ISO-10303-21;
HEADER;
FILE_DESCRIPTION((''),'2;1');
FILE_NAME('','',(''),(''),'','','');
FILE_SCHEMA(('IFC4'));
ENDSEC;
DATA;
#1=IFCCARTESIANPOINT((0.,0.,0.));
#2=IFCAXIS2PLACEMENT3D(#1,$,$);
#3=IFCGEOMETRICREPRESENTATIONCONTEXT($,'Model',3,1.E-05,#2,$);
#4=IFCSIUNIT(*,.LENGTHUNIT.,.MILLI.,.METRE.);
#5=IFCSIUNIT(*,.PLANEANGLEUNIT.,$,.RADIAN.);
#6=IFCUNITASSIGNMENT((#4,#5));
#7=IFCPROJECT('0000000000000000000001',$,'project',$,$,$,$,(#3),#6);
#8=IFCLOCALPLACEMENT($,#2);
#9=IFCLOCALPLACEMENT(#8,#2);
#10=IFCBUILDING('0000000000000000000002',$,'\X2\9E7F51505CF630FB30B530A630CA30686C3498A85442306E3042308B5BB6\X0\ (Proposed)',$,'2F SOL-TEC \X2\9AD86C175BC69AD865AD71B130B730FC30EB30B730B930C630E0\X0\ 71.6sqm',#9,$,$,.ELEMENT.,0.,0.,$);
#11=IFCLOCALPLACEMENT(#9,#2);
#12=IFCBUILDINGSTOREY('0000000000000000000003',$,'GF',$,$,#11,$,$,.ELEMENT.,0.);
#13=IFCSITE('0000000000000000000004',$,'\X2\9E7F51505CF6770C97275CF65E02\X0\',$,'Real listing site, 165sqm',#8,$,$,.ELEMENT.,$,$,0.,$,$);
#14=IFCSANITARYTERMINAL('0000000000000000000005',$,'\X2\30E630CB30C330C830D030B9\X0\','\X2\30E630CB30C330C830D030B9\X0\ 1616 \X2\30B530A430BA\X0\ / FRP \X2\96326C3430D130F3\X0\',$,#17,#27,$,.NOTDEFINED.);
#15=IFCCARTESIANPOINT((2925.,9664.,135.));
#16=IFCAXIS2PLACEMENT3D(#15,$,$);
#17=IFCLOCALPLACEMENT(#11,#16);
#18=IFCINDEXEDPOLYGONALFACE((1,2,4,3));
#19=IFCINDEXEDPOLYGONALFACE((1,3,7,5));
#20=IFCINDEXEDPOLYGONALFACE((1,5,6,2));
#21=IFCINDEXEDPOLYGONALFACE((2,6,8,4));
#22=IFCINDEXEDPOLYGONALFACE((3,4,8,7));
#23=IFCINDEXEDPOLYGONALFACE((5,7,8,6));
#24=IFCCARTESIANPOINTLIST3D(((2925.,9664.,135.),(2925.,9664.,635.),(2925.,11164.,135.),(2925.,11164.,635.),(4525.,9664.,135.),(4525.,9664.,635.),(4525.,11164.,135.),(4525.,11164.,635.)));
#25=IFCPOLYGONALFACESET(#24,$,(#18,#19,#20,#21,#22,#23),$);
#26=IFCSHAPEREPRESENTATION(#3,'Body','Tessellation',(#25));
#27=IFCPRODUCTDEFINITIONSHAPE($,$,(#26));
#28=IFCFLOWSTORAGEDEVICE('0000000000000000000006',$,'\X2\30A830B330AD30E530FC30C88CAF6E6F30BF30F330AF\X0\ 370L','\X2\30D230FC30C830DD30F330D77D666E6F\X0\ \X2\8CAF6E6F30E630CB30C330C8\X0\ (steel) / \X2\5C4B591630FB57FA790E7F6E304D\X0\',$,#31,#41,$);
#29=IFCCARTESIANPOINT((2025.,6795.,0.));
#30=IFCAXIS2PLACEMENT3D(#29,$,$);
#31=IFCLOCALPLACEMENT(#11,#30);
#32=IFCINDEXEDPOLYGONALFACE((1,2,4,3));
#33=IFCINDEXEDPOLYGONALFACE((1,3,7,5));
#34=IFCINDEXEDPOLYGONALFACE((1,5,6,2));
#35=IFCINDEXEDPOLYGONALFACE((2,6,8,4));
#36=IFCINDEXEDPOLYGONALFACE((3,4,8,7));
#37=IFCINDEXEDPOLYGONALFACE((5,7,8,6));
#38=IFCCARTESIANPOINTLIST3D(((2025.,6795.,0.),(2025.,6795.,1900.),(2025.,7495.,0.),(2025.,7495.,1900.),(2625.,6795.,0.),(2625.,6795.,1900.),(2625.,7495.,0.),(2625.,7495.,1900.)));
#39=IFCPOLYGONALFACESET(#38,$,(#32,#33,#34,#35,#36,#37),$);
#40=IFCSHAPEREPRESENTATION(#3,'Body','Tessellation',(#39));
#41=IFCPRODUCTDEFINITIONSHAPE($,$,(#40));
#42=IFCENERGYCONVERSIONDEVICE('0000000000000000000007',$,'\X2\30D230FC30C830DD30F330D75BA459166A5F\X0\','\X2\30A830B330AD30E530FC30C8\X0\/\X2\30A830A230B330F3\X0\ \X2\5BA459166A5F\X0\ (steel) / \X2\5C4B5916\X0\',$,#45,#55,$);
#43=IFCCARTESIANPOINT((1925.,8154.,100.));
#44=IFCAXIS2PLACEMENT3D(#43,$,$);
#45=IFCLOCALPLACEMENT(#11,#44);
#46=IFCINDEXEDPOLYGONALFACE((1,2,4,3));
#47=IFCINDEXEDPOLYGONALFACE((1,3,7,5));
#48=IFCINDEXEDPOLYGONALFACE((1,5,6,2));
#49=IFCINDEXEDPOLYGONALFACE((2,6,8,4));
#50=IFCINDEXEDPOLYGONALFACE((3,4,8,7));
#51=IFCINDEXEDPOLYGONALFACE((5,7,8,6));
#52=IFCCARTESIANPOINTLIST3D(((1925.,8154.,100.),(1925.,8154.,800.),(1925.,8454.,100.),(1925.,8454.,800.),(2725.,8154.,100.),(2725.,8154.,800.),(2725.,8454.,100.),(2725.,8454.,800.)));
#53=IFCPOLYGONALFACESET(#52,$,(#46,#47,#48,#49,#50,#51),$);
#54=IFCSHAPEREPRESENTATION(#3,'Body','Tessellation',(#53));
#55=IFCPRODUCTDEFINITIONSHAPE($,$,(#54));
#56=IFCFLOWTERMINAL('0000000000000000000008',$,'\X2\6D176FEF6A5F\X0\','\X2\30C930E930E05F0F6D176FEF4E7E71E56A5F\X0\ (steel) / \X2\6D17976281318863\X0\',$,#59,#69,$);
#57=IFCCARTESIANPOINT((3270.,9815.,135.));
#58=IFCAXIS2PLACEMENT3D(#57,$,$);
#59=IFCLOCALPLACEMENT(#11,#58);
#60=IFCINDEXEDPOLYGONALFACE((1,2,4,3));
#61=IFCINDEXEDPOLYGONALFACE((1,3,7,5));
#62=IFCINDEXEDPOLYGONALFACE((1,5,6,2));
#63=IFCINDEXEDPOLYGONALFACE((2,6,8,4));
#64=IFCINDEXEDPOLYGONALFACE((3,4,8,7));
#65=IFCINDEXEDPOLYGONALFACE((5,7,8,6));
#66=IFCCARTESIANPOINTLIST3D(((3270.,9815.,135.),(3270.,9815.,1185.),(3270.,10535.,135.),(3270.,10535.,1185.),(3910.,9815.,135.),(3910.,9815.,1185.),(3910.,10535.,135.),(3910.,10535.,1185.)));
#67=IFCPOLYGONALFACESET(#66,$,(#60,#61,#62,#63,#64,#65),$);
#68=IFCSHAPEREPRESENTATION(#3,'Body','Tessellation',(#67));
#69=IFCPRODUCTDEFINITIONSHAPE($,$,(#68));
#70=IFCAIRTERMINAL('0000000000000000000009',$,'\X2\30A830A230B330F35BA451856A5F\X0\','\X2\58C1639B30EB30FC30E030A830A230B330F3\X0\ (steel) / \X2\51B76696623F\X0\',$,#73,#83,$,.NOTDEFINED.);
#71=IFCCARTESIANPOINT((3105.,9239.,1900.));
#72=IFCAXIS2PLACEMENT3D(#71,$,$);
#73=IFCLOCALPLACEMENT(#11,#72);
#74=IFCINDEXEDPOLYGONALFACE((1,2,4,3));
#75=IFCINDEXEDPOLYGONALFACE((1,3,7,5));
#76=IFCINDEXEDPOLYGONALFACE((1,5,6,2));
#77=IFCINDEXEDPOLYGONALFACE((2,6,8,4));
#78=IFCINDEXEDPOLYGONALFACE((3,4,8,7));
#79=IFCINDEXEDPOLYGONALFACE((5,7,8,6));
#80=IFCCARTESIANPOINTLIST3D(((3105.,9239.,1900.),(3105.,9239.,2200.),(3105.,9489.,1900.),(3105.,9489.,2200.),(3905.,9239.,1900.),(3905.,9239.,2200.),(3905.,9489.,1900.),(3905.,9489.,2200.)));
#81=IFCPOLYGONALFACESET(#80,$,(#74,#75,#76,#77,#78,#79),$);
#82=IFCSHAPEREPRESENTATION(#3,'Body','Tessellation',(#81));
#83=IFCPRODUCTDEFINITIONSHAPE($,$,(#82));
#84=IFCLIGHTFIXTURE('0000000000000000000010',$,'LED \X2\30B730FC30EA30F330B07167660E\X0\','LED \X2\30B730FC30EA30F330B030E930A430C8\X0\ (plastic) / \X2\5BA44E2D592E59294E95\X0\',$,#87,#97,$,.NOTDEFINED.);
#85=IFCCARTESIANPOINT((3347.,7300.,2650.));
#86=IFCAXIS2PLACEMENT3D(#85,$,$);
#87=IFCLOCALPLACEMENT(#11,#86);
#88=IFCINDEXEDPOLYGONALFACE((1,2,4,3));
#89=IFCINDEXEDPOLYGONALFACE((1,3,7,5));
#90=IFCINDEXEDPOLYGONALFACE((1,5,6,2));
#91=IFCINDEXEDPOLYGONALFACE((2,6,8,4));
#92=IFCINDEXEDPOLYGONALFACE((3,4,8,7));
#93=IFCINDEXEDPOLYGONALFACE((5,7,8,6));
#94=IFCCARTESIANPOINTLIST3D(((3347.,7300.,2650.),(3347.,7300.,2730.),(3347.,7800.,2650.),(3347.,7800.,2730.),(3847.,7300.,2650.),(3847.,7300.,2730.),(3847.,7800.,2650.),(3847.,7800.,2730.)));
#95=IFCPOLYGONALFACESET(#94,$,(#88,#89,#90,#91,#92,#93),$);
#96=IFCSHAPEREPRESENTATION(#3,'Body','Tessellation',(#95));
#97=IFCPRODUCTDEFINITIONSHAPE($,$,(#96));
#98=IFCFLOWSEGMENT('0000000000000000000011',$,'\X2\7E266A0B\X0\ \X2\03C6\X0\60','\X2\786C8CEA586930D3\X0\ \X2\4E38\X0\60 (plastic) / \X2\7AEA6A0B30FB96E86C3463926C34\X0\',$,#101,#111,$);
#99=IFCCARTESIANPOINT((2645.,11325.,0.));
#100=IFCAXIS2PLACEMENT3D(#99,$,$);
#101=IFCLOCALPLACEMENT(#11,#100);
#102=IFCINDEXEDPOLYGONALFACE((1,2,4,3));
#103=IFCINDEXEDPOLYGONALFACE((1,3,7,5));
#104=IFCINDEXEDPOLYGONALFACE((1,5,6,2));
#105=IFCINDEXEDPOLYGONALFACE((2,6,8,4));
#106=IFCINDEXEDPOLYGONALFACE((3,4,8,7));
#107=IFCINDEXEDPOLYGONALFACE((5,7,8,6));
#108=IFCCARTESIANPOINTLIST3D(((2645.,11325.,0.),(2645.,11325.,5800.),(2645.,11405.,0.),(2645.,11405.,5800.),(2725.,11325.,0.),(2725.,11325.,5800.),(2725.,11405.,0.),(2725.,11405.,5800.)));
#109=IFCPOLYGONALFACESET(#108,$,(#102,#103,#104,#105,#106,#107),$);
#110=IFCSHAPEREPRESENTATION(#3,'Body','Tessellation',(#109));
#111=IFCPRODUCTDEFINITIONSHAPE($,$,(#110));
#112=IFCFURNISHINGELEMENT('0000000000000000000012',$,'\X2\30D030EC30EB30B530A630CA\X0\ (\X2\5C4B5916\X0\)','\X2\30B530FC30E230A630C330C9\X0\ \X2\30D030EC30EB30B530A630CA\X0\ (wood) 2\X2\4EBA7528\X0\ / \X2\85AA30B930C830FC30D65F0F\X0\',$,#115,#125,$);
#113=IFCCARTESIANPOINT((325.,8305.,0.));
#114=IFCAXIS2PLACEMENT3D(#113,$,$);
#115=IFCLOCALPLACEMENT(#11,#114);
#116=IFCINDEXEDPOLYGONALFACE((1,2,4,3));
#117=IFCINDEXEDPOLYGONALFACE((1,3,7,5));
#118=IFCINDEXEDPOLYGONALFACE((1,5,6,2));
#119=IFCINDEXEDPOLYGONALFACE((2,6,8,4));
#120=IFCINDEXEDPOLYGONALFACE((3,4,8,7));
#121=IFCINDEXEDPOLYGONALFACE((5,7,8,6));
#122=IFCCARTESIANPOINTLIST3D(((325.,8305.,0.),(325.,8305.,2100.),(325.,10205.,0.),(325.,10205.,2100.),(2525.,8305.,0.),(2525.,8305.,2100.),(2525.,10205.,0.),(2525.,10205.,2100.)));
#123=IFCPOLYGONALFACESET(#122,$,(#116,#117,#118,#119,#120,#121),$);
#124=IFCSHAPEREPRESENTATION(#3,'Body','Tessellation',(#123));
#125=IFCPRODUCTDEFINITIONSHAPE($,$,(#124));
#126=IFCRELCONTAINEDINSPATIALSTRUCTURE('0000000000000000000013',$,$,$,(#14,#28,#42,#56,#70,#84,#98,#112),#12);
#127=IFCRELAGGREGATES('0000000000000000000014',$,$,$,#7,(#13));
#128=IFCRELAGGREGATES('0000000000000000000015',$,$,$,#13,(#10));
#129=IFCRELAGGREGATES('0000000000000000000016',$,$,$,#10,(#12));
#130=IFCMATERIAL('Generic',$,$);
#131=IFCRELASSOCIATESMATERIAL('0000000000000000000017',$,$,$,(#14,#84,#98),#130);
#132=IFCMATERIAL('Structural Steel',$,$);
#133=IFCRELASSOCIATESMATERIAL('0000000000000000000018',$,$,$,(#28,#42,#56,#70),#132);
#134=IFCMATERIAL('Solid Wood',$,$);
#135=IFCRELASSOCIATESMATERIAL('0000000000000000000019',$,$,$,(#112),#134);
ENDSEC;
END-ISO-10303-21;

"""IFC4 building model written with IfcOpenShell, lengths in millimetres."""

from ifc_helpers import new_model, si_unit, frame, frame_2d, origin, place, context, project, spatial, rectangle, extrude, material, element, save


model = new_model("IFC4")

# Units and contexts
model_context = context("Model", 3, precision=1e-05, world=origin())
ifc_project = project(units=[si_unit("LENGTHUNIT", "METRE", prefix="MILLI"), si_unit("PLANEANGLEUNIT", "RADIAN")], contexts=[model_context])

# Site, building, storey
site_placement = place(None, origin())
site = spatial("IfcSite", under=ifc_project, at=site_placement, Name="鹿児島県霧島市", ObjectType="Real listing site, 165sqm", CompositionType="ELEMENT", RefElevation=0.0)
building_placement = place(site_placement, origin())
building = spatial("IfcBuilding", under=site, at=building_placement, Name="鹿児島・サウナと水風呂のある家 (Proposed)", ObjectType="2F SOL-TEC 高気密高断熱シールシステム 71.6sqm", CompositionType="ELEMENT", ElevationOfRefHeight=0.0, ElevationOfTerrain=0.0)
storey_placement = place(building_placement, origin())
storey = spatial("IfcBuildingStorey", under=building, at=storey_placement, Name="GF", CompositionType="ELEMENT", Elevation=0.0)

# Shared definitions
ifc_material_1 = material(Name="Solid Wood")

# Shared definitions
ifc_material_2 = material(Name="Generic")

# Sanitary terminal
sanitary_terminal_placement = place(storey_placement, frame((2925.0, 9664.0, 135.0)))
element("IfcSanitaryTerminal", 1, at=sanitary_terminal_placement, inside=storey, material=ifc_material_2, Name="ユニットバス", Description="ユニットバス 1616 サイズ / FRP 防水パン", PredefinedType="NOTDEFINED", context=model_context, shape_type="SweptSolid", body=[
    extrude(rectangle(XDim=1600.0, YDim=1500.0, at=frame_2d((800.0, 750.0))), frame((2925.0, 9664.0, 135.0)), (0.0, 0.0, 1.0), 500.0),
])

# Flow storage device
ifc_material_3 = material(Name="Structural Steel")
flow_storage_device_placement = place(storey_placement, frame((2025.0, 6795.0, 0.0)))
element("IfcFlowStorageDevice", 2, at=flow_storage_device_placement, inside=storey, material=ifc_material_3, Name="エコキュート貯湯タンク 370L", Description="ヒートポンプ給湯 貯湯ユニット (steel) / 屋外・基礎置き", context=model_context, shape_type="SweptSolid", body=[
    extrude(rectangle(XDim=600.0, YDim=700.0, at=frame_2d((300.0, 350.0))), frame((2025.0, 6795.0, 0.0)), (0.0, 0.0, 1.0), 1900.0),
])

# Energy conversion device
energy_conversion_device_placement = place(storey_placement, frame((1925.0, 8154.0, 100.0)))
element("IfcEnergyConversionDevice", 3, at=energy_conversion_device_placement, inside=storey, material=ifc_material_3, Name="ヒートポンプ室外機", Description="エコキュート/エアコン 室外機 (steel) / 屋外", context=model_context, shape_type="SweptSolid", body=[
    extrude(rectangle(XDim=800.0, YDim=300.0, at=frame_2d((400.0, 150.0))), frame((1925.0, 8154.0, 100.0)), (0.0, 0.0, 1.0), 700.0),
])

# Flow terminal
flow_terminal_placement = place(storey_placement, frame((3270.0, 9815.0, 135.0)))
element("IfcFlowTerminal", 4, at=flow_terminal_placement, inside=storey, material=ifc_material_3, Name="洗濯機", Description="ドラム式洗濯乾燥機 (steel) / 洗面脱衣", context=model_context, shape_type="SweptSolid", body=[
    extrude(rectangle(XDim=640.0, YDim=720.0, at=frame_2d((320.0, 360.0))), frame((3270.0, 9815.0, 135.0)), (0.0, 0.0, 1.0), 1050.0),
])

# Air terminal
air_terminal_placement = place(storey_placement, frame((3105.0, 9239.0, 1900.0)))
element("IfcAirTerminal", 5, at=air_terminal_placement, inside=storey, material=ifc_material_3, Name="エアコン室内機", Description="壁掛ルームエアコン (steel) / 冷暖房", PredefinedType="NOTDEFINED", context=model_context, shape_type="SweptSolid", body=[
    extrude(rectangle(XDim=800.0, YDim=250.0, at=frame_2d((400.0, 125.0))), frame((3105.0, 9239.0, 1900.0)), (0.0, 0.0, 1.0), 300.0),
])

# Light fixture
light_fixture_placement = place(storey_placement, frame((3347.0, 7300.0, 2650.0)))
element("IfcLightFixture", 6, at=light_fixture_placement, inside=storey, material=ifc_material_2, Name="LED シーリング照明", Description="LED シーリングライト (plastic) / 室中央天井", PredefinedType="NOTDEFINED", context=model_context, shape_type="SweptSolid", body=[
    extrude(rectangle(XDim=500.0, YDim=500.0, at=frame_2d((250.0, 250.0))), frame((3347.0, 7300.0, 2650.0)), (0.0, 0.0, 1.0), 80.0),
])

# Flow segment
flow_segment_placement = place(storey_placement, frame((2645.0, 11325.0, 0.0)))
element("IfcFlowSegment", 7, at=flow_segment_placement, inside=storey, material=ifc_material_2, Name="縦樋 φ60", Description="硬質塩ビ 丸60 (plastic) / 竪樋・雨水排水", context=model_context, shape_type="SweptSolid", body=[
    extrude(rectangle(XDim=80.0, YDim=80.0, at=frame_2d((40.0, 40.0))), frame((2645.0, 11325.0, 0.0)), (0.0, 0.0, 1.0), 5800.0),
])

# Furnishing element
furnishing_placement = place(storey_placement, frame((325.0, 8305.0, 0.0)))
element("IfcFurnishingElement", 8, at=furnishing_placement, inside=storey, material=ifc_material_1, Name="バレルサウナ (屋外)", Description="サーモウッド バレルサウナ (wood) 2人用 / 薪ストーブ式", context=model_context, shape_type="SweptSolid", body=[
    extrude(rectangle(XDim=2200.0, YDim=1900.0, at=frame_2d((1100.0, 950.0))), frame((325.0, 8305.0, 0.0)), (0.0, 0.0, 1.0), 2100.0),
])

save(model, "model.ifc")
